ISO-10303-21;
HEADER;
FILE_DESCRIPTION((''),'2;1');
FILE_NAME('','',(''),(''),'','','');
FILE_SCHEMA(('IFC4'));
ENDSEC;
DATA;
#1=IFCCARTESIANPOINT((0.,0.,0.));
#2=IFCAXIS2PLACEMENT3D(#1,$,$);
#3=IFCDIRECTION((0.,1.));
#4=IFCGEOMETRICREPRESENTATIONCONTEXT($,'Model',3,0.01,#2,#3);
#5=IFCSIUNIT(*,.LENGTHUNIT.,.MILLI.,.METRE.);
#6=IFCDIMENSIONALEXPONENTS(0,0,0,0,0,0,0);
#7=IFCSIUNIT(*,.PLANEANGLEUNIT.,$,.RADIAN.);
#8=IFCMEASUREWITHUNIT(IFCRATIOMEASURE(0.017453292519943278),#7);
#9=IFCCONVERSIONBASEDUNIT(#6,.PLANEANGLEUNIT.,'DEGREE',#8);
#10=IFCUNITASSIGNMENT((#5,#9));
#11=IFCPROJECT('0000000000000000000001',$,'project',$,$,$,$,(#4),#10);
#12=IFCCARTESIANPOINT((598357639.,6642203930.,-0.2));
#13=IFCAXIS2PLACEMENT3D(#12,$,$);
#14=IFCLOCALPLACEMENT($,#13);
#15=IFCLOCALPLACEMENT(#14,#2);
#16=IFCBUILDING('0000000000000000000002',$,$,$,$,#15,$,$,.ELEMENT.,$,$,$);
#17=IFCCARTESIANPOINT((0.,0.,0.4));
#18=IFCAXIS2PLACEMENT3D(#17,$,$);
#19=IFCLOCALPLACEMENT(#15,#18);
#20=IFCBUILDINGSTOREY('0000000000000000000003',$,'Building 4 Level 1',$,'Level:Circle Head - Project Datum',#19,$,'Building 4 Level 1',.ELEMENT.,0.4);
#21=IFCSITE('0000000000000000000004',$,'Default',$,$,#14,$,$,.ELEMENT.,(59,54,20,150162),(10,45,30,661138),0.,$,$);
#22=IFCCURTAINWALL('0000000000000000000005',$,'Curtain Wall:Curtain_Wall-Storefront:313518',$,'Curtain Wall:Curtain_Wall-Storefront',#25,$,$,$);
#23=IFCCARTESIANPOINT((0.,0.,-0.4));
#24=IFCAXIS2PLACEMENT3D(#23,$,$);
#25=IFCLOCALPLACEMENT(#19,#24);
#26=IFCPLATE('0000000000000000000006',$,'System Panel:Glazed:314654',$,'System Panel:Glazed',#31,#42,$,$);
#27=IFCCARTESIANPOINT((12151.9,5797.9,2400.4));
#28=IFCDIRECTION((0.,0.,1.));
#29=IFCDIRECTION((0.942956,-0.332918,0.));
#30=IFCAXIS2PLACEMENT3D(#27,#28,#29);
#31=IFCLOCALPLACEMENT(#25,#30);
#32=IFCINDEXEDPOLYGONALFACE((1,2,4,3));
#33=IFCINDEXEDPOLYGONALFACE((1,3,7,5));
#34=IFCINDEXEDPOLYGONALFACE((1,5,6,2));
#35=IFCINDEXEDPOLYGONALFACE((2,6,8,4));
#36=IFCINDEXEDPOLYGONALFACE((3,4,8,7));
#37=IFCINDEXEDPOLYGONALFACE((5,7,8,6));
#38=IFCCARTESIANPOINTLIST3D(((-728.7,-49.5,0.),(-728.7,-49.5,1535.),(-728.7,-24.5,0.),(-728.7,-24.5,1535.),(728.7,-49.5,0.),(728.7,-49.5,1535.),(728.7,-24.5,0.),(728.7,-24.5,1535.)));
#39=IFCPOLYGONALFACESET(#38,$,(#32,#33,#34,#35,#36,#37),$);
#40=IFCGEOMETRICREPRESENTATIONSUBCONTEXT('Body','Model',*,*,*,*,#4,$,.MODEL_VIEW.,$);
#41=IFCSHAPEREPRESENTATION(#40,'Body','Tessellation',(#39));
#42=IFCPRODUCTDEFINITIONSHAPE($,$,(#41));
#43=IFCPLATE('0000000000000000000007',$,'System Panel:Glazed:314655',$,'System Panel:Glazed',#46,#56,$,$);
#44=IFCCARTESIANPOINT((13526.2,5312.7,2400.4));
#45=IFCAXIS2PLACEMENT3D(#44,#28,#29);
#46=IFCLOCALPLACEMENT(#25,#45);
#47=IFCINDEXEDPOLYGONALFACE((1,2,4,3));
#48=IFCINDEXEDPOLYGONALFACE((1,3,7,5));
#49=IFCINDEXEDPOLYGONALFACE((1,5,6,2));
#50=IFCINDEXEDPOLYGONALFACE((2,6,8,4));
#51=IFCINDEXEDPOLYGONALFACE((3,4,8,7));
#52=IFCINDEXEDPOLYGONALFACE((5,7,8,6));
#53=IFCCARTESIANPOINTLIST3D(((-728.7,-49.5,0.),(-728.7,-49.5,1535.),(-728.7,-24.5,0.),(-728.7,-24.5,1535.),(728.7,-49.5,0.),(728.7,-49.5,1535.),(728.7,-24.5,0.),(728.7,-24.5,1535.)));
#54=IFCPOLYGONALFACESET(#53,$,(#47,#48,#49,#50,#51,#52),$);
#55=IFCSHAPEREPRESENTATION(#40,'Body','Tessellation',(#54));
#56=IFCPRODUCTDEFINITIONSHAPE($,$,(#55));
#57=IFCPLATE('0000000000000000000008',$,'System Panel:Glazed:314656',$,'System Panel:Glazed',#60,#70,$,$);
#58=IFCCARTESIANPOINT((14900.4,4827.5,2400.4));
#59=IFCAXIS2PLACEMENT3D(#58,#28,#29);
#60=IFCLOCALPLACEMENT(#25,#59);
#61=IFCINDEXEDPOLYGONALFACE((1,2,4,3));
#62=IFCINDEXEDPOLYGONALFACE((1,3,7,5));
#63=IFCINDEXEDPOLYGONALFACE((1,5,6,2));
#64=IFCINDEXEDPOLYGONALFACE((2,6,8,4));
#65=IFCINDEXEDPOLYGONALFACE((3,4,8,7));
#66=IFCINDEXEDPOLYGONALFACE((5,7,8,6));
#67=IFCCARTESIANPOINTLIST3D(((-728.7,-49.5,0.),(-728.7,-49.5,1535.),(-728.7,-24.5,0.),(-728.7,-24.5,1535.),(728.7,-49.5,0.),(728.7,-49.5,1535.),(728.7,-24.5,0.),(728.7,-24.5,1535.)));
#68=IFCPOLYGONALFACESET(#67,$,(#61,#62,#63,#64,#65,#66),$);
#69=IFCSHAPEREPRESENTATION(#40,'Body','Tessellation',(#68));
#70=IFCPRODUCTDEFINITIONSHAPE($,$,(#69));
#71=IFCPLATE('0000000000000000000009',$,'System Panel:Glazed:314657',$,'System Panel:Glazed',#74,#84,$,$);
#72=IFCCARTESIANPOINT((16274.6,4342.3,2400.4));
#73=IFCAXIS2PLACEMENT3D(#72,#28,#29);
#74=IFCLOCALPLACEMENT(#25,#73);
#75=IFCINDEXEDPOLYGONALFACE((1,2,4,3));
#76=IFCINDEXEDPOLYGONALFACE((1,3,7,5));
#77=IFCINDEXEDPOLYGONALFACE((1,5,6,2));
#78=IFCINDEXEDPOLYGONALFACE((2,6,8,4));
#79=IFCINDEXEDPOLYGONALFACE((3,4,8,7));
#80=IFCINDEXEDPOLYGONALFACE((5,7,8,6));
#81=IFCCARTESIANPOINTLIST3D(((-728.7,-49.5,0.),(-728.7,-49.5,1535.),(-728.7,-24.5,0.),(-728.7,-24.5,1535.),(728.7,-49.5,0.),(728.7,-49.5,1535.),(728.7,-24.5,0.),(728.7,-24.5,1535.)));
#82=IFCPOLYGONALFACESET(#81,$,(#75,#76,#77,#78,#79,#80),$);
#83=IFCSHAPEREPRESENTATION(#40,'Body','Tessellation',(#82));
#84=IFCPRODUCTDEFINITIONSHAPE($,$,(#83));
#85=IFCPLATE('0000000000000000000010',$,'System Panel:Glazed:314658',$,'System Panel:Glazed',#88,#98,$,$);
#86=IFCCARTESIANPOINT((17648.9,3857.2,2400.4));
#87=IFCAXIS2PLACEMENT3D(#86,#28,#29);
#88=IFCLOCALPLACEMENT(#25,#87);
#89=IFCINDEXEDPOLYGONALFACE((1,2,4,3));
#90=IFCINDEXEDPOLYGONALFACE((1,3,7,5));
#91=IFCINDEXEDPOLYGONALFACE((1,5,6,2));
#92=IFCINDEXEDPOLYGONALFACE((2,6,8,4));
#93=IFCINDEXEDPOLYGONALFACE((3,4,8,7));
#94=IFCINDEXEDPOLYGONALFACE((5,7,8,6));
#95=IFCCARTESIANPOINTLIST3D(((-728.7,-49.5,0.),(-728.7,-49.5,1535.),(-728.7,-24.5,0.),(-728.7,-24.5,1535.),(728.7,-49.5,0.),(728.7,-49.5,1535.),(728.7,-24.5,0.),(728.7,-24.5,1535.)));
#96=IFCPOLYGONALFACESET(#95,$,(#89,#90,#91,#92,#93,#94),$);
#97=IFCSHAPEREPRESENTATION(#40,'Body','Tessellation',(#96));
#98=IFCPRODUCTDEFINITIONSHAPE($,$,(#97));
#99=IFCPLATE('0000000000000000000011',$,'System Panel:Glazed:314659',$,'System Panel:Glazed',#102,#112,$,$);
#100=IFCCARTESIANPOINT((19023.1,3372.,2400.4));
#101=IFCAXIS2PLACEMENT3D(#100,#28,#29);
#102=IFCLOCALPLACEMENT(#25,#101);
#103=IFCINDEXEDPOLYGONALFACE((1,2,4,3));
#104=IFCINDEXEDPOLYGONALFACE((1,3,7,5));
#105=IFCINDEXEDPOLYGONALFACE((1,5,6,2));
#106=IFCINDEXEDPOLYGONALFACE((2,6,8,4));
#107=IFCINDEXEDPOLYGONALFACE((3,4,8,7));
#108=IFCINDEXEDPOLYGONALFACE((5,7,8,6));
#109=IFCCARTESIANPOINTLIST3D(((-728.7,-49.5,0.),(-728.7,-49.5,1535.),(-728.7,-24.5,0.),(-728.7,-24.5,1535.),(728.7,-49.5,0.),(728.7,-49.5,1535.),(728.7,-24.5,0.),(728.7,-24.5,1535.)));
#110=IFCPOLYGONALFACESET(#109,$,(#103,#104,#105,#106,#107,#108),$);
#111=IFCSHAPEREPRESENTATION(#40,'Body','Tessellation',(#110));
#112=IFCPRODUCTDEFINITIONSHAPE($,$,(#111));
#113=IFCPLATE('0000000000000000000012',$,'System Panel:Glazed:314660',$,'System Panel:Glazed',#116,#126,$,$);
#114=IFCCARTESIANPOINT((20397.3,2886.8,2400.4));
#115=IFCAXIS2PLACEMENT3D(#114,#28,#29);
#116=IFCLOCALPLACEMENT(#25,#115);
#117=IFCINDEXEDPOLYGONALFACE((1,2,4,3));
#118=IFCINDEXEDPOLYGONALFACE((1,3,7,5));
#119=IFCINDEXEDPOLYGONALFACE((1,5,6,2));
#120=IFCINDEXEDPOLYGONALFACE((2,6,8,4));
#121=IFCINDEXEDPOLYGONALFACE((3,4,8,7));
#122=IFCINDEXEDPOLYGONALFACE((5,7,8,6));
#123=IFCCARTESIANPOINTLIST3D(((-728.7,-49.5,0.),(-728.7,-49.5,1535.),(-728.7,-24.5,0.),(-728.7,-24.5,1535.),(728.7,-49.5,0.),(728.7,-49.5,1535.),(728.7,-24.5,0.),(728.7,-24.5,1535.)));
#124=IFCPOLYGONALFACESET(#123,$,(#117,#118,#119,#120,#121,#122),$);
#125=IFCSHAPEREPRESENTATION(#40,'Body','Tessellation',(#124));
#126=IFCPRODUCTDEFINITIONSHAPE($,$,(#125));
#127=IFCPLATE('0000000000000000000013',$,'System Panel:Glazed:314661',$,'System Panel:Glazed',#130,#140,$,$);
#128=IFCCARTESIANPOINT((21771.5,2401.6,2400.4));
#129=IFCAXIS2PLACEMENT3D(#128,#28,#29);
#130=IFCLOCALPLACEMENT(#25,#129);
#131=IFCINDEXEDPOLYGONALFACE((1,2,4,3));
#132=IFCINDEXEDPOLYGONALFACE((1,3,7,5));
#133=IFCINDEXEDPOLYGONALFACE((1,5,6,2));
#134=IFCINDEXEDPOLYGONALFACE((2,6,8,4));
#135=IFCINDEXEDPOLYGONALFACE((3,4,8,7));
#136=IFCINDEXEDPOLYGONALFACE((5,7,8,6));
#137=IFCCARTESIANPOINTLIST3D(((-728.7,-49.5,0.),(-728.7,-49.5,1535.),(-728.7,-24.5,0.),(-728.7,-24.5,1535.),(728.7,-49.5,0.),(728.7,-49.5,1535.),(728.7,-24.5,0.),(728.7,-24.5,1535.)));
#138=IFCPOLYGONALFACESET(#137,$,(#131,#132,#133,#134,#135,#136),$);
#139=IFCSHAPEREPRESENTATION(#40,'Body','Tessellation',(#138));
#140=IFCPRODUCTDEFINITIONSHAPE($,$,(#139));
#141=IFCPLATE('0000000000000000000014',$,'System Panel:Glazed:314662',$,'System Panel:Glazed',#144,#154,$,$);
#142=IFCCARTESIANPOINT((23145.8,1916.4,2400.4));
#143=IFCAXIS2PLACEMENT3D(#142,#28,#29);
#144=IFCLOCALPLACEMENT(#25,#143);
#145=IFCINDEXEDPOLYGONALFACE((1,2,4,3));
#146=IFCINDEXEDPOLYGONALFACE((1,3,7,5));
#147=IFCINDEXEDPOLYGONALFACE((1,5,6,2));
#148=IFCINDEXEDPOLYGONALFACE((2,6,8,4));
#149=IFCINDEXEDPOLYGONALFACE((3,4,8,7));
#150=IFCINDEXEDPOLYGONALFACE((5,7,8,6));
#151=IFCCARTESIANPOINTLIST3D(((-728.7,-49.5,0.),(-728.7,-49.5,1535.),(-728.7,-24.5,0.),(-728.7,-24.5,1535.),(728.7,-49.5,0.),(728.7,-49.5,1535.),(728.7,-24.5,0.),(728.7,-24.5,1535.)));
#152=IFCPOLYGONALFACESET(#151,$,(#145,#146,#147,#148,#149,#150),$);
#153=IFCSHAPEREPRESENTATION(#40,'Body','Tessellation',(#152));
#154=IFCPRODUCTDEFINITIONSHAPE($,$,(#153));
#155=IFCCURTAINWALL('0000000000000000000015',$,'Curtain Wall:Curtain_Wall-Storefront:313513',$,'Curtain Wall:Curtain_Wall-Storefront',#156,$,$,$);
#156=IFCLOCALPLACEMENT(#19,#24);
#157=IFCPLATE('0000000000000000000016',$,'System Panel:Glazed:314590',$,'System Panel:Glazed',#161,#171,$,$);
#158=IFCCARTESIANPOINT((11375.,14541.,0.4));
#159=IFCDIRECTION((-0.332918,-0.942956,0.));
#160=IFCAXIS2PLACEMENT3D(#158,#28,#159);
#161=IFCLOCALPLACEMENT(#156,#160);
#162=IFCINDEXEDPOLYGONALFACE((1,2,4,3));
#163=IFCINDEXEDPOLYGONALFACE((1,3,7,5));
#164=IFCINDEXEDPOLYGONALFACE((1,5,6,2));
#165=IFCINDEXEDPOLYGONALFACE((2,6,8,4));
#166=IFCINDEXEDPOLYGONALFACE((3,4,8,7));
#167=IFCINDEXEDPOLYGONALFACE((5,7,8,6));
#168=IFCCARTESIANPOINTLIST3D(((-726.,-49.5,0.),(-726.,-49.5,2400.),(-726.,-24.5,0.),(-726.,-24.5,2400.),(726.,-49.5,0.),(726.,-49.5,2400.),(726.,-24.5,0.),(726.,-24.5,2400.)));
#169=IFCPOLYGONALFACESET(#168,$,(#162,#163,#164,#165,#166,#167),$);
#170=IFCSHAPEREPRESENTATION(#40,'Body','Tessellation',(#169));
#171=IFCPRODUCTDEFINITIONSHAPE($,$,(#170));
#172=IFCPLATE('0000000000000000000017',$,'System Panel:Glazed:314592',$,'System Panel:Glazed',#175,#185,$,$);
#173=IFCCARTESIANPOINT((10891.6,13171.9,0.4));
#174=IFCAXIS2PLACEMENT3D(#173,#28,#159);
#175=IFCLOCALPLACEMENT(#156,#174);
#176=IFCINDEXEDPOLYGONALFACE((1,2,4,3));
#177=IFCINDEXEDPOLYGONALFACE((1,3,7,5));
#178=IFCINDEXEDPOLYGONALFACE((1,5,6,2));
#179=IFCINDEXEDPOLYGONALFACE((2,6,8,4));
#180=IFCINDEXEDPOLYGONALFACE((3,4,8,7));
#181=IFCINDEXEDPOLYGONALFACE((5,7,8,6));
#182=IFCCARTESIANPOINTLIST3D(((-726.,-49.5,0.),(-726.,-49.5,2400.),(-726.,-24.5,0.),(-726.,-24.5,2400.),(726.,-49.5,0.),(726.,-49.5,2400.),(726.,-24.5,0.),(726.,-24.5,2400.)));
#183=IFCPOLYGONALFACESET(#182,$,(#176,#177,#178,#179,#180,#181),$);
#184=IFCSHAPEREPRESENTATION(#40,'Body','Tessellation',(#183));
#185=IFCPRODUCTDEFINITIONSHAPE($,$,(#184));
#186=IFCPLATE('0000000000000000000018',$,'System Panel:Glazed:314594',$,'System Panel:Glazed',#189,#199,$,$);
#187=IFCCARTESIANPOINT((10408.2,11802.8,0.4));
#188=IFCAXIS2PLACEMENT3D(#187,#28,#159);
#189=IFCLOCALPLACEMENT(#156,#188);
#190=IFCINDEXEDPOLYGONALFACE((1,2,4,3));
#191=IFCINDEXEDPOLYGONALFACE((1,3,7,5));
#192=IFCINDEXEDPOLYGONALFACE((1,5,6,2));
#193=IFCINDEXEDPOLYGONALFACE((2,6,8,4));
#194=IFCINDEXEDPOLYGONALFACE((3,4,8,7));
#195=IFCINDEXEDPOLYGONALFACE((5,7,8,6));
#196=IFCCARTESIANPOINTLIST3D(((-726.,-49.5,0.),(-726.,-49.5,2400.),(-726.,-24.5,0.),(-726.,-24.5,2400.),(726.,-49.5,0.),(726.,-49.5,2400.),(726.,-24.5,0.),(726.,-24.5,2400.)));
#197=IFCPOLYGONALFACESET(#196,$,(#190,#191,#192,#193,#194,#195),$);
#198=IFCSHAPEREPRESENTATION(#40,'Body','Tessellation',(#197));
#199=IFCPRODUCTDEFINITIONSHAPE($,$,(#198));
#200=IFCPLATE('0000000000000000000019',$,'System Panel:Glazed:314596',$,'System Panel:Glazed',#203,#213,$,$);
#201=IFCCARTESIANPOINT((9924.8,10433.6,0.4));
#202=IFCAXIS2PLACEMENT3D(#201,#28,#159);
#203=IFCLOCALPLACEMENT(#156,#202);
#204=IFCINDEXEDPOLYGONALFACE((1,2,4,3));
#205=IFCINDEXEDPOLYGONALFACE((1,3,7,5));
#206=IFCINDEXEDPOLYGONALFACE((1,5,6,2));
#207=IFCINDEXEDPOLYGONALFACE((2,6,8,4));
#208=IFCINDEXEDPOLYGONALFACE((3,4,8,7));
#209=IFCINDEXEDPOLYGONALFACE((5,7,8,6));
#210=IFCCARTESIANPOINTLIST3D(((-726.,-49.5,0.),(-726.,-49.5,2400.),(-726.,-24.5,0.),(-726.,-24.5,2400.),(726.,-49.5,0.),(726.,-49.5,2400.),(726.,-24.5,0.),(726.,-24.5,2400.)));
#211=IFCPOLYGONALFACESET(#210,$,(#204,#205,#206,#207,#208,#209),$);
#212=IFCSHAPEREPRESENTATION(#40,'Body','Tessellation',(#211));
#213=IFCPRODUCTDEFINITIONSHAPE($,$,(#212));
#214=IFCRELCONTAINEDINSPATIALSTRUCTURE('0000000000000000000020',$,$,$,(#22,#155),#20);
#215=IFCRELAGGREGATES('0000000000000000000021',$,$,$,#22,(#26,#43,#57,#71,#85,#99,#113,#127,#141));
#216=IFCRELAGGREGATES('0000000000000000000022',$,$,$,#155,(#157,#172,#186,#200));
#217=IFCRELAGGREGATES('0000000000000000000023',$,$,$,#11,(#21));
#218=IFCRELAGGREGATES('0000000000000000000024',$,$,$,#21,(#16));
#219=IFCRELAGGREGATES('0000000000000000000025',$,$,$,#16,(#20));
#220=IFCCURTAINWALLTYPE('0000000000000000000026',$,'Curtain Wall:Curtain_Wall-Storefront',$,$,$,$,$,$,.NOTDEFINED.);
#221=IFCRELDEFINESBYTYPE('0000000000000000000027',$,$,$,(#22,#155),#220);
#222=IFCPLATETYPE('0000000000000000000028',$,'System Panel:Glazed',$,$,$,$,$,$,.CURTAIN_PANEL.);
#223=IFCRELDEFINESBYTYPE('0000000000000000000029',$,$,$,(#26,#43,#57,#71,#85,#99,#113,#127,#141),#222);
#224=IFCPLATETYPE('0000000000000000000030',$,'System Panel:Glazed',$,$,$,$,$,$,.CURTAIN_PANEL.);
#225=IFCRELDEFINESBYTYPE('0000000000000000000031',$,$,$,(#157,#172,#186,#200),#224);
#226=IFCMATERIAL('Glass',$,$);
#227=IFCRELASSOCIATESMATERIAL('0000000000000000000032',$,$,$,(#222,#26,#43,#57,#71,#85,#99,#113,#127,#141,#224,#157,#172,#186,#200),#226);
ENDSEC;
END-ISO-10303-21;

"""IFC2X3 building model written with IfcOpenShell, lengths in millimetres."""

from ifc_helpers import new_model, entity, si_unit, converted_unit, direction, frame, frame_2d, origin, place, context, subcontext, project, spatial, rectangle, extrude, source, transform, mapped, material, type_object, type_shapes, element, aggregate, save


model = new_model("IFC2X3")

# Units and contexts
model_context = context("Model", 3, precision=0.01, world=origin(), true_north=direction((0.0, 1.0)))
body_context = subcontext(model_context, "Body", "Model", "MODEL_VIEW")
ifc_project = project(units=[si_unit("LENGTHUNIT", "METRE", prefix="MILLI"), converted_unit("PLANEANGLEUNIT", "DEGREE", entity("IfcRatioMeasure", 0.017453292519943278), si_unit("PLANEANGLEUNIT", "RADIAN"), dimensions=[0, 0, 0, 0, 0, 0, 0])], contexts=[model_context])

# Site, building, storey
site_placement = place(None, frame((598357639.0, 6642203930.0, -0.2)))
site = spatial("IfcSite", under=ifc_project, at=site_placement, Name="Default", CompositionType="ELEMENT", RefLatitude=(59, 54, 20, 150162), RefLongitude=(10, 45, 30, 661138), RefElevation=0.0)
building_placement = place(site_placement, origin())
building = spatial("IfcBuilding", under=site, at=building_placement, CompositionType="ELEMENT")
storey_placement = place(building_placement, frame((0.0, 0.0, 0.4)))
storey = spatial("IfcBuildingStorey", under=building, at=storey_placement, Name="Building 4 Level 1", ObjectType="Level:Circle Head - Project Datum", LongName="Building 4 Level 1", CompositionType="ELEMENT", Elevation=0.4)

# Curtain walls, plates
curtain_wall_type = type_object("IfcCurtainWallType", Name="Curtain Wall:Curtain_Wall-Storefront", PredefinedType="NOTDEFINED")
curtain_wall_1_placement = place(storey_placement, frame((0.0, 0.0, -0.4)))
curtain_wall_1 = element("IfcCurtainWall", 1, at=curtain_wall_1_placement, inside=storey, type_object=curtain_wall_type, Name="Curtain Wall:Curtain_Wall-Storefront:313518", ObjectType="Curtain Wall:Curtain_Wall-Storefront")
ifc_material_1 = material(Name="Glass")
plate_type_1 = type_object("IfcPlateType", Name="System Panel:Glazed", PredefinedType="CURTAIN_PANEL", material=ifc_material_1)
shared_shape_1 = source(origin(), body_context, "Body", "SweptSolid", [
    extrude(rectangle(XDim=25.0, YDim=1457.4, at=frame_2d((0.0, 0.0), x_axis=(1.0, 0.0))), frame((0.0, -37.0, 0.0), z_axis=(0.0, 0.0, 1.0), x_axis=(0.0, 1.0, 0.0)), (0.0, 0.0, 1.0), 1535.0),
])
type_shapes(plate_type_1, [shared_shape_1])
plate_1_placement = place(curtain_wall_1_placement, frame((12151.9, 5797.9, 2400.4), z_axis=(0.0, 0.0, 1.0), x_axis=(0.942956, -0.332918, 0.0)))
plate_1 = element("IfcPlate", 2, at=plate_1_placement, type_object=plate_type_1, material=ifc_material_1, Name="System Panel:Glazed:314654", ObjectType="System Panel:Glazed", context=body_context, shape_type="MappedRepresentation", body=[
    mapped(shared_shape_1, transform((0.0, 0.0, 0.0), scale=1.0)),
])
plate_2_placement = place(curtain_wall_1_placement, frame((13526.2, 5312.7, 2400.4), z_axis=(0.0, 0.0, 1.0), x_axis=(0.942956, -0.332918, 0.0)))
plate_2 = element("IfcPlate", 3, at=plate_2_placement, type_object=plate_type_1, material=ifc_material_1, Name="System Panel:Glazed:314655", ObjectType="System Panel:Glazed", context=body_context, shape_type="MappedRepresentation", body=[
    mapped(shared_shape_1, transform((0.0, 0.0, 0.0), scale=1.0)),
])
plate_3_placement = place(curtain_wall_1_placement, frame((14900.4, 4827.5, 2400.4), z_axis=(0.0, 0.0, 1.0), x_axis=(0.942956, -0.332918, 0.0)))
plate_3 = element("IfcPlate", 4, at=plate_3_placement, type_object=plate_type_1, material=ifc_material_1, Name="System Panel:Glazed:314656", ObjectType="System Panel:Glazed", context=body_context, shape_type="MappedRepresentation", body=[
    mapped(shared_shape_1, transform((0.0, 0.0, 0.0), scale=1.0)),
])
plate_4_placement = place(curtain_wall_1_placement, frame((16274.6, 4342.3, 2400.4), z_axis=(0.0, 0.0, 1.0), x_axis=(0.942956, -0.332918, 0.0)))
plate_4 = element("IfcPlate", 5, at=plate_4_placement, type_object=plate_type_1, material=ifc_material_1, Name="System Panel:Glazed:314657", ObjectType="System Panel:Glazed", context=body_context, shape_type="MappedRepresentation", body=[
    mapped(shared_shape_1, transform((0.0, 0.0, 0.0), scale=1.0)),
])
plate_5_placement = place(curtain_wall_1_placement, frame((17648.9, 3857.2, 2400.4), z_axis=(0.0, 0.0, 1.0), x_axis=(0.942956, -0.332918, 0.0)))
plate_5 = element("IfcPlate", 6, at=plate_5_placement, type_object=plate_type_1, material=ifc_material_1, Name="System Panel:Glazed:314658", ObjectType="System Panel:Glazed", context=body_context, shape_type="MappedRepresentation", body=[
    mapped(shared_shape_1, transform((0.0, 0.0, 0.0), scale=1.0)),
])
plate_6_placement = place(curtain_wall_1_placement, frame((19023.1, 3372.0, 2400.4), z_axis=(0.0, 0.0, 1.0), x_axis=(0.942956, -0.332918, 0.0)))
plate_6 = element("IfcPlate", 7, at=plate_6_placement, type_object=plate_type_1, material=ifc_material_1, Name="System Panel:Glazed:314659", ObjectType="System Panel:Glazed", context=body_context, shape_type="MappedRepresentation", body=[
    mapped(shared_shape_1, transform((0.0, 0.0, 0.0), scale=1.0)),
])
plate_7_placement = place(curtain_wall_1_placement, frame((20397.3, 2886.8, 2400.4), z_axis=(0.0, 0.0, 1.0), x_axis=(0.942956, -0.332918, 0.0)))
plate_7 = element("IfcPlate", 8, at=plate_7_placement, type_object=plate_type_1, material=ifc_material_1, Name="System Panel:Glazed:314660", ObjectType="System Panel:Glazed", context=body_context, shape_type="MappedRepresentation", body=[
    mapped(shared_shape_1, transform((0.0, 0.0, 0.0), scale=1.0)),
])
plate_8_placement = place(curtain_wall_1_placement, frame((21771.5, 2401.6, 2400.4), z_axis=(0.0, 0.0, 1.0), x_axis=(0.942956, -0.332918, 0.0)))
plate_8 = element("IfcPlate", 9, at=plate_8_placement, type_object=plate_type_1, material=ifc_material_1, Name="System Panel:Glazed:314661", ObjectType="System Panel:Glazed", context=body_context, shape_type="MappedRepresentation", body=[
    mapped(shared_shape_1, transform((0.0, 0.0, 0.0), scale=1.0)),
])
plate_9_placement = place(curtain_wall_1_placement, frame((23145.8, 1916.4, 2400.4), z_axis=(0.0, 0.0, 1.0), x_axis=(0.942956, -0.332918, 0.0)))
plate_9 = element("IfcPlate", 10, at=plate_9_placement, type_object=plate_type_1, material=ifc_material_1, Name="System Panel:Glazed:314662", ObjectType="System Panel:Glazed", context=body_context, shape_type="MappedRepresentation", body=[
    mapped(shared_shape_1, transform((0.0, 0.0, 0.0), scale=1.0)),
])
aggregate(curtain_wall_1, [plate_1, plate_2, plate_3, plate_4, plate_5, plate_6, plate_7, plate_8, plate_9])
curtain_wall_2_placement = place(storey_placement, frame((0.0, 0.0, -0.4)))
curtain_wall_2 = element("IfcCurtainWall", 11, at=curtain_wall_2_placement, inside=storey, type_object=curtain_wall_type, Name="Curtain Wall:Curtain_Wall-Storefront:313513", ObjectType="Curtain Wall:Curtain_Wall-Storefront")
plate_type_2 = type_object("IfcPlateType", Name="System Panel:Glazed", PredefinedType="CURTAIN_PANEL", material=ifc_material_1)
shared_shape_2 = source(origin(), body_context, "Body", "SweptSolid", [
    extrude(rectangle(XDim=25.0, YDim=1451.9, at=frame_2d((0.0, 0.0), x_axis=(1.0, 0.0))), frame((0.0, -37.0, 0.0), z_axis=(0.0, 0.0, 1.0), x_axis=(0.0, 1.0, 0.0)), (0.0, 0.0, 1.0), 2400.0),
])
type_shapes(plate_type_2, [shared_shape_2])
plate_10_placement = place(curtain_wall_2_placement, frame((11375.0, 14541.0, 0.4), z_axis=(0.0, 0.0, 1.0), x_axis=(-0.332918, -0.942956, 0.0)))
plate_10 = element("IfcPlate", 12, at=plate_10_placement, type_object=plate_type_2, material=ifc_material_1, Name="System Panel:Glazed:314590", ObjectType="System Panel:Glazed", context=body_context, shape_type="MappedRepresentation", body=[
    mapped(shared_shape_2, transform((0.0, 0.0, 0.0), scale=1.0)),
])
plate_11_placement = place(curtain_wall_2_placement, frame((10891.6, 13171.9, 0.4), z_axis=(0.0, 0.0, 1.0), x_axis=(-0.332918, -0.942956, 0.0)))
plate_11 = element("IfcPlate", 13, at=plate_11_placement, type_object=plate_type_2, material=ifc_material_1, Name="System Panel:Glazed:314592", ObjectType="System Panel:Glazed", context=body_context, shape_type="MappedRepresentation", body=[
    mapped(shared_shape_2, transform((0.0, 0.0, 0.0), scale=1.0)),
])
plate_12_placement = place(curtain_wall_2_placement, frame((10408.2, 11802.8, 0.4), z_axis=(0.0, 0.0, 1.0), x_axis=(-0.332918, -0.942956, 0.0)))
plate_12 = element("IfcPlate", 14, at=plate_12_placement, type_object=plate_type_2, material=ifc_material_1, Name="System Panel:Glazed:314594", ObjectType="System Panel:Glazed", context=body_context, shape_type="MappedRepresentation", body=[
    mapped(shared_shape_2, transform((0.0, 0.0, 0.0), scale=1.0)),
])
plate_13_placement = place(curtain_wall_2_placement, frame((9924.8, 10433.6, 0.4), z_axis=(0.0, 0.0, 1.0), x_axis=(-0.332918, -0.942956, 0.0)))
plate_13 = element("IfcPlate", 15, at=plate_13_placement, type_object=plate_type_2, material=ifc_material_1, Name="System Panel:Glazed:314596", ObjectType="System Panel:Glazed", context=body_context, shape_type="MappedRepresentation", body=[
    mapped(shared_shape_2, transform((0.0, 0.0, 0.0), scale=1.0)),
])
aggregate(curtain_wall_2, [plate_10, plate_11, plate_12, plate_13])

save(model, "model.ifc")
